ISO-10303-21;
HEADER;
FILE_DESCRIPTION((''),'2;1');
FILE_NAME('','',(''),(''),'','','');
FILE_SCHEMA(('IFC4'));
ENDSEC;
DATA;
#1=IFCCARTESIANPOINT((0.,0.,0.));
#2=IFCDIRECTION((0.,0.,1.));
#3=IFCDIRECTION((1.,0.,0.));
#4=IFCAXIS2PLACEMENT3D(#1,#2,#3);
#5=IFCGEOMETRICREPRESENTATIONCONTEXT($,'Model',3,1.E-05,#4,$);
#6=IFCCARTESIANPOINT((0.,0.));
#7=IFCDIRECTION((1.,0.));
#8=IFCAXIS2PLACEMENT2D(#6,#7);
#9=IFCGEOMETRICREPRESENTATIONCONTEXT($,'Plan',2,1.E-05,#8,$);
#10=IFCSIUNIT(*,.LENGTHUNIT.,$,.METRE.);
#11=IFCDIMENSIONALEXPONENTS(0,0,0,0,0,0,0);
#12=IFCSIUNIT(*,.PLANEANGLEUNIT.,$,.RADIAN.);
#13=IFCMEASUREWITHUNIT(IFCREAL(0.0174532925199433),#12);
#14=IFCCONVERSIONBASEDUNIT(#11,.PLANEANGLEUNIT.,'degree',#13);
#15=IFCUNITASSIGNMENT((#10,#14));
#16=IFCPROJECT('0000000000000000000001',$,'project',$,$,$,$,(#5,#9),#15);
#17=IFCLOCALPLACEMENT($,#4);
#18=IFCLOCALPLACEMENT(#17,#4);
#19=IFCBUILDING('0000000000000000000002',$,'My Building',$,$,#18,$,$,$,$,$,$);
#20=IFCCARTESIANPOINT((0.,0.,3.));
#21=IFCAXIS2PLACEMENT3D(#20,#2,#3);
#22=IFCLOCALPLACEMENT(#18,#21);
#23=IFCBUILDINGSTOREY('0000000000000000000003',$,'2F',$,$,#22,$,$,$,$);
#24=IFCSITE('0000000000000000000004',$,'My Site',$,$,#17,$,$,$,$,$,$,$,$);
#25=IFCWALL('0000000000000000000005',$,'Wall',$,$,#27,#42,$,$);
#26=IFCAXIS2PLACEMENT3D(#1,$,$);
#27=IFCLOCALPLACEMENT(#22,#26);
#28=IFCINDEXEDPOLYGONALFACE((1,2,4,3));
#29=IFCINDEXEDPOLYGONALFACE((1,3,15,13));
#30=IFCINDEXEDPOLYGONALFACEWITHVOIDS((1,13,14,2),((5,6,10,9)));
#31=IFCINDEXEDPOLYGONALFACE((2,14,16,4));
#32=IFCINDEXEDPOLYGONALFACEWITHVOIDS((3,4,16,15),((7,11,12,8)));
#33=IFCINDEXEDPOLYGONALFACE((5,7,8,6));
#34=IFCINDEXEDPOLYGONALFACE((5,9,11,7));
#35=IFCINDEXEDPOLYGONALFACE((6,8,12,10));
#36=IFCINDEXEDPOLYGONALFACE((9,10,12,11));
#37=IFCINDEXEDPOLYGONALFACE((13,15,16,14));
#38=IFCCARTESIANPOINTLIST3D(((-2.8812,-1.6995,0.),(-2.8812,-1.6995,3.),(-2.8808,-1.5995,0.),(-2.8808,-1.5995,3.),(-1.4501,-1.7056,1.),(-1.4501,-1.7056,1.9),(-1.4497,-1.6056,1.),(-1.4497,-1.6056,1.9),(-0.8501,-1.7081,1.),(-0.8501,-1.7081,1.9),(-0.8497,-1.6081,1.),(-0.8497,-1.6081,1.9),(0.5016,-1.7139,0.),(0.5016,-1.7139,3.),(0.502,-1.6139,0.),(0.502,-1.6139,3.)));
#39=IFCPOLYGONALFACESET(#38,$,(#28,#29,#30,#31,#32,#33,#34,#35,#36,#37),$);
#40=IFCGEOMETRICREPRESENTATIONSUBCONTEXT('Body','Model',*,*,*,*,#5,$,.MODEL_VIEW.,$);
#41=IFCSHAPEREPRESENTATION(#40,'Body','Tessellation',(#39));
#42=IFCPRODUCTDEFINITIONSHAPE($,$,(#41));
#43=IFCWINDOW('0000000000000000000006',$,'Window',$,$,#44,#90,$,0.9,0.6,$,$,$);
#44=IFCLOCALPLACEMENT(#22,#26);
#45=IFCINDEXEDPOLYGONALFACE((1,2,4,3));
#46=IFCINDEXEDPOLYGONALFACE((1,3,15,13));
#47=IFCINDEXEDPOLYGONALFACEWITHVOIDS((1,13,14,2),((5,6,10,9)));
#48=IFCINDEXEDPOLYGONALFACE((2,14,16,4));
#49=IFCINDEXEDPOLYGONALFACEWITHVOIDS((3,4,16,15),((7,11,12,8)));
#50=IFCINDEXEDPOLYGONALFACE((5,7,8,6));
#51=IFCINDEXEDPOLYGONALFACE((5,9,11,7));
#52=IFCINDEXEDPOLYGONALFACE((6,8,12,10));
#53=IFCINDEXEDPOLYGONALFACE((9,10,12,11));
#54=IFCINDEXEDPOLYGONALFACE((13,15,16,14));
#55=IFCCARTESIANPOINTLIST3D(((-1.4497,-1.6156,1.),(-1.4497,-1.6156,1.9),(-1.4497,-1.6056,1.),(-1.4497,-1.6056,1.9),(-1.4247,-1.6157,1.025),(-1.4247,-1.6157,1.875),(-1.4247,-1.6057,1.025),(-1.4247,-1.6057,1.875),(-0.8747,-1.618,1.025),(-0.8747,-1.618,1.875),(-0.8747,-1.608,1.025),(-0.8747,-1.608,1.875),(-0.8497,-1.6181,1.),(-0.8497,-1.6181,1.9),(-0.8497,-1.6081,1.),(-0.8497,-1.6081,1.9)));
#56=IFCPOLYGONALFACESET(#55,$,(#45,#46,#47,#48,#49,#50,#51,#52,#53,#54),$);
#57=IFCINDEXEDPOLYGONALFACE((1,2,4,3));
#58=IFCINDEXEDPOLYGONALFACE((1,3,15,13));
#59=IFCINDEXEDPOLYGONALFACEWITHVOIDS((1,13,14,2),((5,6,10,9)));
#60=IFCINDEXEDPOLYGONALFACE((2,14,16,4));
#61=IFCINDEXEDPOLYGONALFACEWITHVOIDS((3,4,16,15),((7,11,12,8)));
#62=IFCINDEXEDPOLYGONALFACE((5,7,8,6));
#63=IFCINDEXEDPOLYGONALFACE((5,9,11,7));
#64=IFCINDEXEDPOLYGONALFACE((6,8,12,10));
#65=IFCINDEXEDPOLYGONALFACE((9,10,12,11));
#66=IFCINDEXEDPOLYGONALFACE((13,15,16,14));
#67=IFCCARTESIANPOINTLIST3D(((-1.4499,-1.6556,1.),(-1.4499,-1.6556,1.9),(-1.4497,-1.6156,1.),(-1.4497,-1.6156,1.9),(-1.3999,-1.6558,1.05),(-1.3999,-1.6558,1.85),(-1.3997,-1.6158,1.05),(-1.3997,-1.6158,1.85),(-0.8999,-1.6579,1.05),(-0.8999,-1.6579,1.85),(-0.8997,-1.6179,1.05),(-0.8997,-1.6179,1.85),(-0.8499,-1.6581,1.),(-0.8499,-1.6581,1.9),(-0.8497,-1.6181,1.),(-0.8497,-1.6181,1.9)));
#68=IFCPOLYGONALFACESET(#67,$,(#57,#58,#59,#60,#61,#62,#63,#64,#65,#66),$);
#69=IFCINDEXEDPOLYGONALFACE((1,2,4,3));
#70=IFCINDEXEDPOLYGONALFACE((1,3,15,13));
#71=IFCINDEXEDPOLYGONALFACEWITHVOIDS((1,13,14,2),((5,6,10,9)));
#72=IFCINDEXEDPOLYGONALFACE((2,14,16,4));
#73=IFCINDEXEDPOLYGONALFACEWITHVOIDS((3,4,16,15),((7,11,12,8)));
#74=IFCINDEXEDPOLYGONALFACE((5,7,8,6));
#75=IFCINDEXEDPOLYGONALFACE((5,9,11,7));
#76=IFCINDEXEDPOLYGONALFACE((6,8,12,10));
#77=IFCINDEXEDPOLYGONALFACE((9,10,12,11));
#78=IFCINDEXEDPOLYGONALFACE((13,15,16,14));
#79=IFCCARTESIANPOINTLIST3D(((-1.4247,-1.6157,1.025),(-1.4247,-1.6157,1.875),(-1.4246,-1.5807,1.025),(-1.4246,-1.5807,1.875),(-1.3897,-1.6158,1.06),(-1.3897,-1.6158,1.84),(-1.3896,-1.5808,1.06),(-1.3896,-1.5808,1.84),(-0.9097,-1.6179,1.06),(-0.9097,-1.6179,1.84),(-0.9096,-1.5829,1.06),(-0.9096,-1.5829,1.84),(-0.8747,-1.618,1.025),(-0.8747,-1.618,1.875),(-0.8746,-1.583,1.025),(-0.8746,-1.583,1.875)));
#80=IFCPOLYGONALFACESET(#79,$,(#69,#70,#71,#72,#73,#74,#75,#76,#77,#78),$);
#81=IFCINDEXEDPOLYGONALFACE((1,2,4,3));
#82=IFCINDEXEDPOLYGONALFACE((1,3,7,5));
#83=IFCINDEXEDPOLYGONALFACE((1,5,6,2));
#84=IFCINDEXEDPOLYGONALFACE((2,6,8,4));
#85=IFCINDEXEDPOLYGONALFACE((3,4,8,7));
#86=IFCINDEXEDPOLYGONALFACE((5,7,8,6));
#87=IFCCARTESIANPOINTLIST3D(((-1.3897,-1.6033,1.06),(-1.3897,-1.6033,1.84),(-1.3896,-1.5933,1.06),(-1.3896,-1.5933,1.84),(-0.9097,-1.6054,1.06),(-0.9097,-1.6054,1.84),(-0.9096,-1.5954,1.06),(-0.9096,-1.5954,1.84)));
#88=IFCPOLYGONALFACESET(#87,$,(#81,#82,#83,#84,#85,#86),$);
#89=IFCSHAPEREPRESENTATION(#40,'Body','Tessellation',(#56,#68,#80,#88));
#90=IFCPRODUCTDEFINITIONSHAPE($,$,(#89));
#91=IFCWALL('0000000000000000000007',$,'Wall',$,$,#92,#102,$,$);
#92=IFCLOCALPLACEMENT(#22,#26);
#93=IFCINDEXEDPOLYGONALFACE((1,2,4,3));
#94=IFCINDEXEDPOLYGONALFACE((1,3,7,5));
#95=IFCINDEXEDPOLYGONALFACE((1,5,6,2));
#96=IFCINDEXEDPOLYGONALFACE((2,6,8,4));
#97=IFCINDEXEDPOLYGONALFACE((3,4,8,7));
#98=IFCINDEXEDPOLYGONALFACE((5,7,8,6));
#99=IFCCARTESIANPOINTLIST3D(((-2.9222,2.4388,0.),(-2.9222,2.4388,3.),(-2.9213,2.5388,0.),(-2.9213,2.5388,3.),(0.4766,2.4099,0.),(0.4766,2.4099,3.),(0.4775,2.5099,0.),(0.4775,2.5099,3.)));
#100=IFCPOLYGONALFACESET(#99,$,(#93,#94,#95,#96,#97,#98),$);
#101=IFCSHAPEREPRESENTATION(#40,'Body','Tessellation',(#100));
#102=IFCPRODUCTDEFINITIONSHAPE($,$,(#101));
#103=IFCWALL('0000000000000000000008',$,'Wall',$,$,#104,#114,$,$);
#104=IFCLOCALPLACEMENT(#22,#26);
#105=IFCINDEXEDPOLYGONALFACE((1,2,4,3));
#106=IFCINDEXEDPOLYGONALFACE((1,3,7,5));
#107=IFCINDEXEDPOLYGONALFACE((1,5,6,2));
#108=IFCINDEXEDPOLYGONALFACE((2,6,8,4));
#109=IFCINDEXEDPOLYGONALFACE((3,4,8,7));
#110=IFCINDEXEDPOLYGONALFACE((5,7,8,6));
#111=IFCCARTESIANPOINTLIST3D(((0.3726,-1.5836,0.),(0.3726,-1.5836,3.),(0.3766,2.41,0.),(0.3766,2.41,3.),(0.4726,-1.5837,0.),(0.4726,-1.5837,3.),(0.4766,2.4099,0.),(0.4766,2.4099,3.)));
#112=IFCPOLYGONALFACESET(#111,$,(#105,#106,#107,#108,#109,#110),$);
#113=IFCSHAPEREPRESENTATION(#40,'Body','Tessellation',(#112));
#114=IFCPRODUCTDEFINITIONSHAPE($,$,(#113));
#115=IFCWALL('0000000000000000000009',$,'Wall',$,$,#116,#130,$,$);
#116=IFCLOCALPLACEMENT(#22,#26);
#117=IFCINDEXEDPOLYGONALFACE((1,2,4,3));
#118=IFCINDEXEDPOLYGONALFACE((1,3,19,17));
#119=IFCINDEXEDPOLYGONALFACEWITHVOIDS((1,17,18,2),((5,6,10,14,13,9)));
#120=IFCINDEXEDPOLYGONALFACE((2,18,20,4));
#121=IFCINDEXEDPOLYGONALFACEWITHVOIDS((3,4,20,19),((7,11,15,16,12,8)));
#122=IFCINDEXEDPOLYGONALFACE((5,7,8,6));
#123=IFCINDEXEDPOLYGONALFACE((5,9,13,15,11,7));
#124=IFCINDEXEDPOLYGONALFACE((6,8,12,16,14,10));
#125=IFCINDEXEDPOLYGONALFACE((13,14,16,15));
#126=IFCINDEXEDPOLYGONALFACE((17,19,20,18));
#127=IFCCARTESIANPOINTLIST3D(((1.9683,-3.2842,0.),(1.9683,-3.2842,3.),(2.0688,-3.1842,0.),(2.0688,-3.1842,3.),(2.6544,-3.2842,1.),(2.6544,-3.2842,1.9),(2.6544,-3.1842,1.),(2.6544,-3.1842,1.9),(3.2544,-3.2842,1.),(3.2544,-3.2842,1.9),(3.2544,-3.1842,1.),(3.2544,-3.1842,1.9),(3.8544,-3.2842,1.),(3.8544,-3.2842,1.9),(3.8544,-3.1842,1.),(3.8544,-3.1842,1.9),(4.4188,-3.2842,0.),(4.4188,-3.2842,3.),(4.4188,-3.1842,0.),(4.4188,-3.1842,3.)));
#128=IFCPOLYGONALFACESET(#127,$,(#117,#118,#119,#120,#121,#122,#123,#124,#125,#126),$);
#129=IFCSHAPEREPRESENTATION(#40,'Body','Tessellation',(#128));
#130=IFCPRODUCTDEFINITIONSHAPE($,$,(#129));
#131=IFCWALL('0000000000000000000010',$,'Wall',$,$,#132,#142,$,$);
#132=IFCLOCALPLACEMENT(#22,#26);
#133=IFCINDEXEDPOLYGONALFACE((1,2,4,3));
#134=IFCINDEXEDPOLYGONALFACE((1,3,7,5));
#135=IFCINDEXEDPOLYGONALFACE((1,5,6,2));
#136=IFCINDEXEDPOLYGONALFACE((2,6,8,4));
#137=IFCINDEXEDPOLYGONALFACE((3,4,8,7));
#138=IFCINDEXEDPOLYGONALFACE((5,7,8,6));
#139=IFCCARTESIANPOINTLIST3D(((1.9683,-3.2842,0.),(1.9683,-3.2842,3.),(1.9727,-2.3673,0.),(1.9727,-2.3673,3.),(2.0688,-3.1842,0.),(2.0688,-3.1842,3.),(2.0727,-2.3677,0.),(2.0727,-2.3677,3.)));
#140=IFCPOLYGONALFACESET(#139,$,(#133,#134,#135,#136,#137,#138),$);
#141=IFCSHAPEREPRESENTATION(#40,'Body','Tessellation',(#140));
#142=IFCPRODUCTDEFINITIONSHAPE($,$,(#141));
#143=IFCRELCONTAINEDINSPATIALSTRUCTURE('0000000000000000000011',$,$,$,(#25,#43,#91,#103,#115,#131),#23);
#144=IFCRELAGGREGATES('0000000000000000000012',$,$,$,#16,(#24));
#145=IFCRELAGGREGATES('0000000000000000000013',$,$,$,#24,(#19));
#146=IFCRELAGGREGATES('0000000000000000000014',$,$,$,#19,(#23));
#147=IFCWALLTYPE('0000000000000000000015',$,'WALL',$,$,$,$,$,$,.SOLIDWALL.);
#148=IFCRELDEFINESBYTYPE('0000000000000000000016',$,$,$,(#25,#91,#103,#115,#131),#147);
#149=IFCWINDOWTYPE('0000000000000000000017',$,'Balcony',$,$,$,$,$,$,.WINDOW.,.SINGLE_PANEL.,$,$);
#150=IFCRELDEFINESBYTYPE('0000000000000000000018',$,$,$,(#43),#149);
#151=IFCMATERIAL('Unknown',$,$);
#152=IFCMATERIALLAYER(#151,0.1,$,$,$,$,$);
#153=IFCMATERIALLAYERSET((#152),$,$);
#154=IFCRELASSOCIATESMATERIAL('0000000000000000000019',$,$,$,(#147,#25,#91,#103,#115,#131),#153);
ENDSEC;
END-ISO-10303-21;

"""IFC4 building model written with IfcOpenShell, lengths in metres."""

from ifc_helpers import new_model, entity, si_unit, converted_unit, frame, origin_with_axes, origin_2d_with_axis, place, context, subcontext, project, spatial, line, indexed_curve, outline, extrude, shape, source, transform, mapped, material, layer, layer_set, layer_usage, type_object, type_shapes, element, fill, save


model = new_model("IFC4")

# Units and contexts
model_context = context("Model", 3, precision=1e-05, world=origin_with_axes())
plan_context = context("Plan", 2, precision=1e-05, world=origin_2d_with_axis())
body_context_1 = subcontext(model_context, "Body", "Model", "MODEL_VIEW")
body_context_2 = subcontext(plan_context, "Body", "Plan", "PLAN_VIEW")
ifc_project = project(units=[si_unit("LENGTHUNIT", "METRE"), converted_unit("PLANEANGLEUNIT", "degree", entity("IfcReal", 0.0174532925199433), si_unit("PLANEANGLEUNIT", "RADIAN"), dimensions=[0, 0, 0, 0, 0, 0, 0])], contexts=[model_context, plan_context])

# Site, building, storey
site_placement = place(None, origin_with_axes())
site = spatial("IfcSite", under=ifc_project, at=site_placement, Name="My Site")
building_placement = place(site_placement, origin_with_axes())
building = spatial("IfcBuilding", under=site, at=building_placement, Name="My Building")
storey_placement = place(building_placement, frame((0.0, 0.0, 3.0), z_axis=(0.0, 0.0, 1.0), x_axis=(1.0, 0.0, 0.0)))
storey = spatial("IfcBuildingStorey", under=building, at=storey_placement, Name="2F")

# Shared definitions
ifc_material = material(Name="Unknown")

# Wall, opening, window
ifc_layer = layer(ifc_material, 0.1)
ifc_layer_set = layer_set([ifc_layer])
ifc_layer_usage_1 = layer_usage(ifc_layer_set, "AXIS2", "POSITIVE", 0.0)
wall_type = type_object("IfcWallType", Name="WALL", PredefinedType="SOLIDWALL", material=ifc_layer_set)
wall_1_placement = place(storey_placement, frame((-2.8812, -1.6995, 0.0), z_axis=(0.0, 0.0, 1.0), x_axis=(0.999991, -0.004277, 0.0)))
wall_1 = element("IfcWall", 1, at=wall_1_placement, inside=storey, type_object=wall_type, material=ifc_layer_usage_1, Name="Wall", context=body_context_1, shape_type="SweptSolid", body=[
    extrude(outline(indexed_curve([(0.0, 0.0), (0.0, 0.1), (3.3828, 0.1), (3.3828, 0.0)], segments=[line(1, 2, 3, 4, 1)])), origin_with_axes(), (0.0, 0.0, 1.0), 3.0),
])
shared_shape_1 = source(origin_with_axes(), body_context_1, "Body", "SweptSolid", [
    extrude(outline(indexed_curve([(0.0, 0.0), (0.6, 0.0), (0.6, 0.9), (0.0, 0.9)], segments=[line(1, 2, 3, 4, 1)])), frame((0.0, -0.6, 0.0), z_axis=(0.0, -1.0, 0.0), x_axis=(1.0, 0.0, 0.0)), (0.0, 0.0, -1.0), 1.2),
])
opening_1_placement = place(wall_1_placement, frame((1.4311, 0.0, 1.0), z_axis=(0.0, 0.0, 1.0), x_axis=(1.0, 0.0, 0.0)))
opening_1 = element("IfcOpeningElement", 2, at=opening_1_placement, cuts=wall_1, PredefinedType="OPENING", context=body_context_1, shape_type="MappedRepresentation", body=[
    mapped(shared_shape_1, transform((0.0, 0.0, 0.0), x_axis=(1.0, 0.0, 0.0), y_axis=(0.0, 1.0, 0.0), z_axis=(0.0, 0.0, 1.0), scale=1.0)),
])
window_type = type_object("IfcWindowType", Name="Balcony", PartitioningType="SINGLE_PANEL", PredefinedType="WINDOW")
shared_shape_2 = source(origin_with_axes(), body_context_1, "Body", "SweptSolid", [
    extrude(outline(indexed_curve([(0.0, 0.0), (0.6, 0.0), (0.6, 0.9), (0.0, 0.9)], segments=[line(1, 2, 3, 4, 1)]), holes=[indexed_curve([(0.025, 0.025), (0.575, 0.025), (0.575, 0.875), (0.025, 0.875)], segments=[line(1, 2, 3, 4, 1)])]), frame((0.0, 0.09, 0.0), z_axis=(0.0, -1.0, 0.0), x_axis=(1.0, 0.0, 0.0)), (0.0, 0.0, -1.0), 0.01),
    extrude(outline(indexed_curve([(0.0, 0.0), (0.6, 0.0), (0.6, 0.9), (0.0, 0.9)], segments=[line(1, 2, 3, 4, 1)]), holes=[indexed_curve([(0.05, 0.05), (0.55, 0.05), (0.55, 0.85), (0.05, 0.85)], segments=[line(1, 2, 3, 4, 1)])]), frame((0.0, 0.05, 0.0), z_axis=(0.0, -1.0, 0.0), x_axis=(1.0, 0.0, 0.0)), (0.0, 0.0, -1.0), 0.04),
    extrude(outline(indexed_curve([(0.0, 0.0), (0.55, 0.0), (0.55, 0.85), (0.0, 0.85)], segments=[line(1, 2, 3, 4, 1)]), holes=[indexed_curve([(0.035, 0.035), (0.515, 0.035), (0.515, 0.815), (0.035, 0.815)], segments=[line(1, 2, 3, 4, 1)])]), frame((0.025, 0.09, 0.025), z_axis=(0.0, -1.0, 0.0), x_axis=(1.0, 0.0, 0.0)), (0.0, 0.0, -1.0), 0.035),
    extrude(outline(indexed_curve([(0.035, 0.035), (0.515, 0.035), (0.515, 0.815), (0.035, 0.815)], segments=[line(1, 2, 3, 4, 1)])), frame((0.025, 0.1025, 0.025), z_axis=(0.0, -1.0, 0.0), x_axis=(1.0, 0.0, 0.0)), (0.0, 0.0, -1.0), 0.01),
])
shared_shape_3 = source(origin_with_axes(), body_context_2, "Body", "Curve2D", [
    entity("IfcIndexedPolyCurve", entity("IfcCartesianPointList2D", [[0.05, 0.05], [0.55, 0.05]])),
    entity("IfcIndexedPolyCurve", entity("IfcCartesianPointList2D", [[0.0, 0.1], [0.025, 0.1], [0.025, 0.09], [0.05, 0.09], [0.05, 0.05], [0.0, 0.05]]), [entity("IfcLineIndex", [1, 2, 3, 4, 5, 6, 1])]),
    entity("IfcIndexedPolyCurve", entity("IfcCartesianPointList2D", [[0.6, 0.1], [0.575, 0.1], [0.575, 0.09], [0.55, 0.09], [0.55, 0.05], [0.6, 0.05]]), [entity("IfcLineIndex", [1, 2, 3, 4, 5, 6, 1])]),
    entity("IfcIndexedPolyCurve", entity("IfcCartesianPointList2D", [[0.025, 0.09], [0.06, 0.09], [0.06, 0.125], [0.025, 0.125]]), [entity("IfcLineIndex", [1, 2, 3, 4, 1])]),
    entity("IfcIndexedPolyCurve", entity("IfcCartesianPointList2D", [[0.575, 0.09], [0.54, 0.09], [0.54, 0.125], [0.575, 0.125]]), [entity("IfcLineIndex", [1, 2, 3, 4, 1])]),
    entity("IfcIndexedPolyCurve", entity("IfcCartesianPointList2D", [[0.06, 0.09], [0.54, 0.09]])),
    entity("IfcIndexedPolyCurve", entity("IfcCartesianPointList2D", [[0.06, 0.125], [0.54, 0.125]])),
    entity("IfcIndexedPolyCurve", entity("IfcCartesianPointList2D", [[0.06, 0.1075], [0.54, 0.1075]])),
])
type_shapes(window_type, [shared_shape_2, shared_shape_3])
window_placement = place(opening_1_placement, frame((0.0, 0.0, 0.0), z_axis=(0.0, 0.0, 1.0), x_axis=(1.0, 0.0, 0.0)))
window = element("IfcWindow", 3, at=window_placement, inside=storey, type_object=window_type, Name="Window", OverallHeight=0.9, OverallWidth=0.6, shapes=[
    shape(body_context_1, "Body", "MappedRepresentation", [mapped(shared_shape_2, transform((0.0, 0.0, 0.0), x_axis=(1.0, 0.0, 0.0), y_axis=(0.0, 1.0, 0.0), z_axis=(0.0, 0.0, 1.0), scale=1.0))]),
    shape(body_context_2, "Body", "MappedRepresentation", [mapped(shared_shape_3, transform((0.0, 0.0, 0.0), x_axis=(1.0, 0.0, 0.0), y_axis=(0.0, 1.0, 0.0), z_axis=(0.0, 0.0, 1.0), scale=1.0))]),
])
fill(opening_1, window)

# Walls
ifc_layer_usage_2 = layer_usage(ifc_layer_set, "AXIS2", "POSITIVE", 0.0)
wall_2_placement = place(storey_placement, frame((-2.9222, 2.4388, 0.0), z_axis=(0.0, 0.0, 1.0), x_axis=(0.999964, -0.008491, 0.0)))
element("IfcWall", 4, at=wall_2_placement, inside=storey, type_object=wall_type, material=ifc_layer_usage_2, Name="Wall", context=body_context_1, shape_type="SweptSolid", body=[
    extrude(outline(indexed_curve([(0.0, 0.0), (0.0, 0.1), (3.3989, 0.1), (3.3989, 0.0)], segments=[line(1, 2, 3, 4, 1)])), origin_with_axes(), (0.0, 0.0, 1.0), 3.0),
])
ifc_layer_usage_3 = layer_usage(ifc_layer_set, "AXIS2", "POSITIVE", 0.0)
wall_3_placement = place(storey_placement, frame((0.4726, -1.5837, 0.0), z_axis=(0.0, 0.0, 1.0), x_axis=(0.000991, 1.0, 0.0)))
element("IfcWall", 5, at=wall_3_placement, inside=storey, type_object=wall_type, material=ifc_layer_usage_3, Name="Wall", context=body_context_1, shape_type="SweptSolid", body=[
    extrude(outline(indexed_curve([(0.0, 0.0), (0.0, 0.1), (3.9936, 0.1), (3.9936, 0.0)], segments=[line(1, 2, 3, 4, 1)])), origin_with_axes(), (0.0, 0.0, 1.0), 3.0),
])

# Wall, openings
ifc_layer_usage_4 = layer_usage(ifc_layer_set, "AXIS2", "POSITIVE", 0.0)
wall_4_placement = place(storey_placement, frame((4.4188, -3.1842, 0.0), z_axis=(0.0, 0.0, 1.0), x_axis=(-1.0, 0.0, 0.0)))
wall_4 = element("IfcWall", 6, at=wall_4_placement, inside=storey, type_object=wall_type, material=ifc_layer_usage_4, Name="Wall", context=body_context_1, shape_type="SweptSolid", body=[
    extrude(outline(indexed_curve([(0.0, 0.0), (0.0, 0.1), (2.4505, 0.1), (2.35, 0.0)], segments=[line(1, 2, 3, 4, 1)])), origin_with_axes(), (0.0, 0.0, 1.0), 3.0),
])
shared_shape_4 = source(origin_with_axes(), body_context_1, "Body", "SweptSolid", [
    extrude(outline(indexed_curve([(0.0, 0.0), (0.6, 0.0), (0.6, 0.9), (0.0, 0.9)], segments=[line(1, 2, 3, 4, 1)])), frame((0.0, -0.6, 0.0), z_axis=(0.0, -1.0, 0.0), x_axis=(1.0, 0.0, 0.0)), (0.0, 0.0, -1.0), 1.2),
])
opening_2_placement = place(wall_4_placement, frame((0.5644, 0.0, 1.0), z_axis=(0.0, 0.0, 1.0), x_axis=(1.0, 0.0, 0.0)))
element("IfcOpeningElement", 7, at=opening_2_placement, cuts=wall_4, PredefinedType="OPENING", context=body_context_1, shape_type="MappedRepresentation", body=[
    mapped(shared_shape_4, transform((0.0, 0.0, 0.0), x_axis=(1.0, 0.0, 0.0), y_axis=(0.0, 1.0, 0.0), z_axis=(0.0, 0.0, 1.0), scale=1.0)),
])
opening_3_placement = place(wall_4_placement, frame((1.1644, 0.0, 1.0), z_axis=(0.0, 0.0, 1.0), x_axis=(1.0, 0.0, 0.0)))
element("IfcOpeningElement", 8, at=opening_3_placement, cuts=wall_4, PredefinedType="OPENING", context=body_context_1, shape_type="MappedRepresentation", body=[
    mapped(shared_shape_4, transform((0.0, 0.0, 0.0), x_axis=(1.0, 0.0, 0.0), y_axis=(0.0, 1.0, 0.0), z_axis=(0.0, 0.0, 1.0), scale=1.0)),
])

# Wall
ifc_layer_usage_5 = layer_usage(ifc_layer_set, "AXIS2", "POSITIVE", 0.0)
wall_5_placement = place(storey_placement, frame((2.0688, -3.1842, 0.0), z_axis=(0.0, 0.0, 1.0), x_axis=(0.00477, 0.999989, 0.0)))
element("IfcWall", 9, at=wall_5_placement, inside=storey, type_object=wall_type, material=ifc_layer_usage_5, Name="Wall", context=body_context_1, shape_type="SweptSolid", body=[
    extrude(outline(indexed_curve([(0.0, 0.0), (-0.1005, 0.1), (0.8165, 0.1), (0.8165, 0.0)], segments=[line(1, 2, 3, 4, 1)])), origin_with_axes(), (0.0, 0.0, 1.0), 3.0),
])

save(model, "model.ifc")
